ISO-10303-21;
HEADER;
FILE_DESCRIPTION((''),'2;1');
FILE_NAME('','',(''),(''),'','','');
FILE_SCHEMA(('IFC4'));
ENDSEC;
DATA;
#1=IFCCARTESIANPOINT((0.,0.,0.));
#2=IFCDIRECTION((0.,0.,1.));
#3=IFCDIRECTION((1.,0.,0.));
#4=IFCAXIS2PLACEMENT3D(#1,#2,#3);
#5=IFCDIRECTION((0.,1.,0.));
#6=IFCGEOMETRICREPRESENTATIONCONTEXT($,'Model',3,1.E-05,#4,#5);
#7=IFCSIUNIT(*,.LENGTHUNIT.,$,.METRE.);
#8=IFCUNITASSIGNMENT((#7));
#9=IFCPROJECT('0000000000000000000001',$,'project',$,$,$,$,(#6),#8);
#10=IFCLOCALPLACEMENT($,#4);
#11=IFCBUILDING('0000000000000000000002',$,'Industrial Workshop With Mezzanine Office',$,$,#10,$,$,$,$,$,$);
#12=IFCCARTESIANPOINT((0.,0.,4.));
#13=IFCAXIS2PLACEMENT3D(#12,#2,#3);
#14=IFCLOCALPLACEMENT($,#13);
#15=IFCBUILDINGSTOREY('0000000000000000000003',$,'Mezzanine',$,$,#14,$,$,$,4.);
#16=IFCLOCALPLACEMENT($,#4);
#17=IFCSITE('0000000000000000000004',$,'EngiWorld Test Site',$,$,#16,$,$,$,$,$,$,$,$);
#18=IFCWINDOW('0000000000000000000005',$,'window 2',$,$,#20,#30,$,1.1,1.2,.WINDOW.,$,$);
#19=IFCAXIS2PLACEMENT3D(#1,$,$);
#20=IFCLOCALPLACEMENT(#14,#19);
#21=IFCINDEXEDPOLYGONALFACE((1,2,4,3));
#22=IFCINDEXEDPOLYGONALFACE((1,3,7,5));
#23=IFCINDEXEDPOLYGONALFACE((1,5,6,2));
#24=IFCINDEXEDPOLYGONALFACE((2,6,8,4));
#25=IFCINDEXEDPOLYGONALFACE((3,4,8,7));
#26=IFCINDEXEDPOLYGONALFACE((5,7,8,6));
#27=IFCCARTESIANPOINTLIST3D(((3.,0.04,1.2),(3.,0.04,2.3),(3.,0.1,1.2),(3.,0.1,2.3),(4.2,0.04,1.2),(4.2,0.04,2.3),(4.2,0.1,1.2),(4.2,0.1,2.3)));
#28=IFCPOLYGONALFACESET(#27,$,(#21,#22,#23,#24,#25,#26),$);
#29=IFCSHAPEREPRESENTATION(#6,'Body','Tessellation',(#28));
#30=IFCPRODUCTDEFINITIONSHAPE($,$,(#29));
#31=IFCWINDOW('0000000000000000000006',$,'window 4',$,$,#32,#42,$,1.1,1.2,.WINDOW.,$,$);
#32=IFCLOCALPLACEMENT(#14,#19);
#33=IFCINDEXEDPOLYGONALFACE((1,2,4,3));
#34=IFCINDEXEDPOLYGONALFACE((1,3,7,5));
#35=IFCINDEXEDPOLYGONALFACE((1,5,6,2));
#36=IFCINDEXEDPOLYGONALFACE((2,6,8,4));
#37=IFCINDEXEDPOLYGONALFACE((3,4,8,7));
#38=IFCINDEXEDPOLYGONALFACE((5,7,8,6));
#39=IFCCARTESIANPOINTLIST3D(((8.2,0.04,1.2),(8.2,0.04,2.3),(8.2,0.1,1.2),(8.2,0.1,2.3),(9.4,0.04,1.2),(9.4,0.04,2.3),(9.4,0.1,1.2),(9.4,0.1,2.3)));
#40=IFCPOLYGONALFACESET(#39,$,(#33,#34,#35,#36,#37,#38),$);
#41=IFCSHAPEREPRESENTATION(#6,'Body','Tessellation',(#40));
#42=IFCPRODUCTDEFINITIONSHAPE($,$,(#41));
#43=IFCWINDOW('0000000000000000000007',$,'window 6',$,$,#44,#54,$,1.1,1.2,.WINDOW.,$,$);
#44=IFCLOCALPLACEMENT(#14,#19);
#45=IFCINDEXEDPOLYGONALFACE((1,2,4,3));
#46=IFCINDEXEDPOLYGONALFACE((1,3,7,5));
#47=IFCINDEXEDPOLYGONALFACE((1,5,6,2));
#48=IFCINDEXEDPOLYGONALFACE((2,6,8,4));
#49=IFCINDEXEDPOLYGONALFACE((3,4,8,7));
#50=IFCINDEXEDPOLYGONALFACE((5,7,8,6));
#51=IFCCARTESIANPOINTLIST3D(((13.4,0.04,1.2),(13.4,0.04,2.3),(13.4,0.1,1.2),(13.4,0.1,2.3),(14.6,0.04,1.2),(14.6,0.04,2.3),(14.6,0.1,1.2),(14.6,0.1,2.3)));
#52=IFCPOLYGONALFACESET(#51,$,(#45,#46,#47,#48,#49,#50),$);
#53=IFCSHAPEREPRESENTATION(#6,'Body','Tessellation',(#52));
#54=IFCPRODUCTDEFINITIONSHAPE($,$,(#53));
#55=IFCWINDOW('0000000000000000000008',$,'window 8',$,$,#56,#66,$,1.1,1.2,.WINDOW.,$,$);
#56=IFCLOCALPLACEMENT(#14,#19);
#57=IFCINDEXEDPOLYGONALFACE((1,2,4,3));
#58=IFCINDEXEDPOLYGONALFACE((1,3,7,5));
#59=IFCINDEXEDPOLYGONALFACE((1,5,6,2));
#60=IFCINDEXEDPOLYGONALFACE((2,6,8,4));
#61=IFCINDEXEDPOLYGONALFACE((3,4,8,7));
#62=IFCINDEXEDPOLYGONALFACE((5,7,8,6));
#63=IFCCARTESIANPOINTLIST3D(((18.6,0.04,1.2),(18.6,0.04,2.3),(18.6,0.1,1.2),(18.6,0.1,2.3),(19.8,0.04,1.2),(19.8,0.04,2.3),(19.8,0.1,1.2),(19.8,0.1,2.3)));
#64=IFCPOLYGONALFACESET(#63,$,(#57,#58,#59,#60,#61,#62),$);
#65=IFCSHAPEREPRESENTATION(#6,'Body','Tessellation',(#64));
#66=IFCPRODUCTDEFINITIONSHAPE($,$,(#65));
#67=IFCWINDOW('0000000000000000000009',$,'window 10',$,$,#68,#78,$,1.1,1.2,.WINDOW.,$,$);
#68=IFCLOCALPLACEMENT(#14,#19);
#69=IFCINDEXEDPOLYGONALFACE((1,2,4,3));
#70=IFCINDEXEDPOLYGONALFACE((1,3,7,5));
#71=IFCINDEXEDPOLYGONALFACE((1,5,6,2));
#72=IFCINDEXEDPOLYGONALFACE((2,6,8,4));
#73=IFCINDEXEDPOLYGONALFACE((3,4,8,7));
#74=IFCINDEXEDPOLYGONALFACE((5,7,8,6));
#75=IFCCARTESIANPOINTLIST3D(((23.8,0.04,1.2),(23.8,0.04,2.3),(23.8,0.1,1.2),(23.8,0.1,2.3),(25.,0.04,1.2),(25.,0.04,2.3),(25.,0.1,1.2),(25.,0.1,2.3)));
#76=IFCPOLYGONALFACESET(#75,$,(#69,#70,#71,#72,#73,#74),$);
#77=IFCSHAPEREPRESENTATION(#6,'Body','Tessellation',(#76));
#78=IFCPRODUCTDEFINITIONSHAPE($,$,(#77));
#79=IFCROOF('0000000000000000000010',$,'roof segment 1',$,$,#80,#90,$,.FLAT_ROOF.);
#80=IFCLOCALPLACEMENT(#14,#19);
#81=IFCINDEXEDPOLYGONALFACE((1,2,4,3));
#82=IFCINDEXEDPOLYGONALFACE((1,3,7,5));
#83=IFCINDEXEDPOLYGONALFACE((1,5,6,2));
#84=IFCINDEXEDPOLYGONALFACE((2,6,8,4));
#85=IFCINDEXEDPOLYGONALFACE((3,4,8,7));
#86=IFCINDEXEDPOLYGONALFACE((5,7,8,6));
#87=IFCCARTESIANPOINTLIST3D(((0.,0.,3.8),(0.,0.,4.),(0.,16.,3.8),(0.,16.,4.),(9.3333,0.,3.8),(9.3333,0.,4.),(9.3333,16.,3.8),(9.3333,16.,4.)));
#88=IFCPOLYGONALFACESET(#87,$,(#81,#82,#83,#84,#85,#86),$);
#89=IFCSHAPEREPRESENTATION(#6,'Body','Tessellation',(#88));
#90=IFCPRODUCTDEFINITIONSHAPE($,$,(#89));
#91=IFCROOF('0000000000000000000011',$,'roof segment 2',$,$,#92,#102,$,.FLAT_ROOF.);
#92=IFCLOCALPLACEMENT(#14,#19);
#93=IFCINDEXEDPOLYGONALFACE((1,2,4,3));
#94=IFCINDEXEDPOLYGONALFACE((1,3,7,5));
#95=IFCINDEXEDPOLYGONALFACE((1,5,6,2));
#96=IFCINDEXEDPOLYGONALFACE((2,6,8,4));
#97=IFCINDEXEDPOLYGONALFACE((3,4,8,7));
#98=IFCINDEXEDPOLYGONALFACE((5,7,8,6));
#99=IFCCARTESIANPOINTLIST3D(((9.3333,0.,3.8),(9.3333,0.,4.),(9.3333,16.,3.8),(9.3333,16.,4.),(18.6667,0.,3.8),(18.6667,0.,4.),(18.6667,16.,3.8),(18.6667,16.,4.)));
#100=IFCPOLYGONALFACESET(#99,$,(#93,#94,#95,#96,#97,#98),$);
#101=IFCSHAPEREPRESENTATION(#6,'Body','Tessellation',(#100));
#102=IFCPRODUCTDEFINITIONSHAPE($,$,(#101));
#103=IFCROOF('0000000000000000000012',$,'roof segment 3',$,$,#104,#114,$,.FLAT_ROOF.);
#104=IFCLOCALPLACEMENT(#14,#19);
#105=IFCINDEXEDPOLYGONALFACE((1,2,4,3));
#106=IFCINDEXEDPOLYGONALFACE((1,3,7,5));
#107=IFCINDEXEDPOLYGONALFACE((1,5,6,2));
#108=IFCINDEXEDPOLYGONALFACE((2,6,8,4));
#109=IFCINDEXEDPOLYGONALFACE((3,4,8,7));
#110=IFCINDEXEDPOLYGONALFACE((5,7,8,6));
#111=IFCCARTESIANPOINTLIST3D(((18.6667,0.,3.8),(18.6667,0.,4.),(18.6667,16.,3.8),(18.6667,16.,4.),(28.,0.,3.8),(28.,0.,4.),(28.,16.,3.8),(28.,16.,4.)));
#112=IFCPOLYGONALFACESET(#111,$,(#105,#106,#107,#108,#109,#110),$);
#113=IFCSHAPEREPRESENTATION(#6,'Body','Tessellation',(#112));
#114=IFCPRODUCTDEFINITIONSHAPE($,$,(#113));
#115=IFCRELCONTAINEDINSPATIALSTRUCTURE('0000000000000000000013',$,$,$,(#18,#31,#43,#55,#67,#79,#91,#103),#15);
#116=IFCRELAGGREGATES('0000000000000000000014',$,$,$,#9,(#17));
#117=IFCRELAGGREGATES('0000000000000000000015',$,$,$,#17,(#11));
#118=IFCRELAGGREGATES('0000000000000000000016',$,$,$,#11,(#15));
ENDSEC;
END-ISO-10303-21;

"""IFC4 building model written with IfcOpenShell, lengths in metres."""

from ifc_helpers import new_model, si_unit, direction, frame, origin_with_axes, origin_2d_with_axis, place, context, project, spatial, rectangle, extrude, element, save


model = new_model("IFC4")

# Units and contexts
model_context = context("Model", 3, precision=1e-05, world=origin_with_axes(), true_north=direction((0.0, 1.0, 0.0)))
ifc_project = project(units=[si_unit("LENGTHUNIT", "METRE")], contexts=[model_context])

# Site, building, storey
site_placement = place(None, origin_with_axes())
site = spatial("IfcSite", under=ifc_project, at=site_placement, Name="EngiWorld Test Site")
building_placement = place(None, origin_with_axes())
building = spatial("IfcBuilding", under=site, at=building_placement, Name="Industrial Workshop With Mezzanine Office")
storey_placement = place(None, frame((0.0, 0.0, 4.0), z_axis=(0.0, 0.0, 1.0), x_axis=(1.0, 0.0, 0.0)))
storey = spatial("IfcBuildingStorey", under=building, at=storey_placement, Name="Mezzanine", Elevation=4.0)

# Windows
for number, where, z_axis, x_axis, name in (
    (1, (3.6, 0.07, 5.2), (0.0, 0.0, 1.0), (1.0, 0.0, 0.0), "window 2"),
    (2, (8.8, 0.07, 5.2), (0.0, 0.0, 1.0), (1.0, 0.0, 0.0), "window 4"),
    (3, (14.0, 0.07, 5.2), (0.0, 0.0, 1.0), (1.0, 0.0, 0.0), "window 6"),
    (4, (19.2, 0.07, 5.2), (0.0, 0.0, 1.0), (1.0, 0.0, 0.0), "window 8"),
    (5, (24.4, 0.07, 5.2), (0.0, 0.0, 1.0), (1.0, 0.0, 0.0), "window 10"),
):
    element("IfcWindow", number, at=place(None, frame(where, z_axis=z_axis, x_axis=x_axis)), inside=storey, Name=name, OverallHeight=1.1, OverallWidth=1.2, PredefinedType="WINDOW", context=model_context, shape_type="SweptSolid", body=[
        extrude(rectangle(XDim=1.2, YDim=0.06, at=origin_2d_with_axis()), origin_with_axes(), (0.0, 0.0, 1.0), 1.1),
    ])

# Roofs
for number, where, z_axis, x_axis, name in (
    (6, (4.6667, 8.0, 7.8), (0.0, 0.0, 1.0), (1.0, 0.0, 0.0), "roof segment 1"),
    (7, (14.0, 8.0, 7.8), (0.0, 0.0, 1.0), (1.0, 0.0, 0.0), "roof segment 2"),
    (8, (23.3333, 8.0, 7.8), (0.0, 0.0, 1.0), (1.0, 0.0, 0.0), "roof segment 3"),
):
    element("IfcRoof", number, at=place(None, frame(where, z_axis=z_axis, x_axis=x_axis)), inside=storey, Name=name, PredefinedType="FLAT_ROOF", context=model_context, shape_type="SweptSolid", body=[
        extrude(rectangle(XDim=9.3333, YDim=16.0, at=origin_2d_with_axis()), origin_with_axes(), (0.0, 0.0, 1.0), 0.2),
    ])

save(model, "model.ifc")
